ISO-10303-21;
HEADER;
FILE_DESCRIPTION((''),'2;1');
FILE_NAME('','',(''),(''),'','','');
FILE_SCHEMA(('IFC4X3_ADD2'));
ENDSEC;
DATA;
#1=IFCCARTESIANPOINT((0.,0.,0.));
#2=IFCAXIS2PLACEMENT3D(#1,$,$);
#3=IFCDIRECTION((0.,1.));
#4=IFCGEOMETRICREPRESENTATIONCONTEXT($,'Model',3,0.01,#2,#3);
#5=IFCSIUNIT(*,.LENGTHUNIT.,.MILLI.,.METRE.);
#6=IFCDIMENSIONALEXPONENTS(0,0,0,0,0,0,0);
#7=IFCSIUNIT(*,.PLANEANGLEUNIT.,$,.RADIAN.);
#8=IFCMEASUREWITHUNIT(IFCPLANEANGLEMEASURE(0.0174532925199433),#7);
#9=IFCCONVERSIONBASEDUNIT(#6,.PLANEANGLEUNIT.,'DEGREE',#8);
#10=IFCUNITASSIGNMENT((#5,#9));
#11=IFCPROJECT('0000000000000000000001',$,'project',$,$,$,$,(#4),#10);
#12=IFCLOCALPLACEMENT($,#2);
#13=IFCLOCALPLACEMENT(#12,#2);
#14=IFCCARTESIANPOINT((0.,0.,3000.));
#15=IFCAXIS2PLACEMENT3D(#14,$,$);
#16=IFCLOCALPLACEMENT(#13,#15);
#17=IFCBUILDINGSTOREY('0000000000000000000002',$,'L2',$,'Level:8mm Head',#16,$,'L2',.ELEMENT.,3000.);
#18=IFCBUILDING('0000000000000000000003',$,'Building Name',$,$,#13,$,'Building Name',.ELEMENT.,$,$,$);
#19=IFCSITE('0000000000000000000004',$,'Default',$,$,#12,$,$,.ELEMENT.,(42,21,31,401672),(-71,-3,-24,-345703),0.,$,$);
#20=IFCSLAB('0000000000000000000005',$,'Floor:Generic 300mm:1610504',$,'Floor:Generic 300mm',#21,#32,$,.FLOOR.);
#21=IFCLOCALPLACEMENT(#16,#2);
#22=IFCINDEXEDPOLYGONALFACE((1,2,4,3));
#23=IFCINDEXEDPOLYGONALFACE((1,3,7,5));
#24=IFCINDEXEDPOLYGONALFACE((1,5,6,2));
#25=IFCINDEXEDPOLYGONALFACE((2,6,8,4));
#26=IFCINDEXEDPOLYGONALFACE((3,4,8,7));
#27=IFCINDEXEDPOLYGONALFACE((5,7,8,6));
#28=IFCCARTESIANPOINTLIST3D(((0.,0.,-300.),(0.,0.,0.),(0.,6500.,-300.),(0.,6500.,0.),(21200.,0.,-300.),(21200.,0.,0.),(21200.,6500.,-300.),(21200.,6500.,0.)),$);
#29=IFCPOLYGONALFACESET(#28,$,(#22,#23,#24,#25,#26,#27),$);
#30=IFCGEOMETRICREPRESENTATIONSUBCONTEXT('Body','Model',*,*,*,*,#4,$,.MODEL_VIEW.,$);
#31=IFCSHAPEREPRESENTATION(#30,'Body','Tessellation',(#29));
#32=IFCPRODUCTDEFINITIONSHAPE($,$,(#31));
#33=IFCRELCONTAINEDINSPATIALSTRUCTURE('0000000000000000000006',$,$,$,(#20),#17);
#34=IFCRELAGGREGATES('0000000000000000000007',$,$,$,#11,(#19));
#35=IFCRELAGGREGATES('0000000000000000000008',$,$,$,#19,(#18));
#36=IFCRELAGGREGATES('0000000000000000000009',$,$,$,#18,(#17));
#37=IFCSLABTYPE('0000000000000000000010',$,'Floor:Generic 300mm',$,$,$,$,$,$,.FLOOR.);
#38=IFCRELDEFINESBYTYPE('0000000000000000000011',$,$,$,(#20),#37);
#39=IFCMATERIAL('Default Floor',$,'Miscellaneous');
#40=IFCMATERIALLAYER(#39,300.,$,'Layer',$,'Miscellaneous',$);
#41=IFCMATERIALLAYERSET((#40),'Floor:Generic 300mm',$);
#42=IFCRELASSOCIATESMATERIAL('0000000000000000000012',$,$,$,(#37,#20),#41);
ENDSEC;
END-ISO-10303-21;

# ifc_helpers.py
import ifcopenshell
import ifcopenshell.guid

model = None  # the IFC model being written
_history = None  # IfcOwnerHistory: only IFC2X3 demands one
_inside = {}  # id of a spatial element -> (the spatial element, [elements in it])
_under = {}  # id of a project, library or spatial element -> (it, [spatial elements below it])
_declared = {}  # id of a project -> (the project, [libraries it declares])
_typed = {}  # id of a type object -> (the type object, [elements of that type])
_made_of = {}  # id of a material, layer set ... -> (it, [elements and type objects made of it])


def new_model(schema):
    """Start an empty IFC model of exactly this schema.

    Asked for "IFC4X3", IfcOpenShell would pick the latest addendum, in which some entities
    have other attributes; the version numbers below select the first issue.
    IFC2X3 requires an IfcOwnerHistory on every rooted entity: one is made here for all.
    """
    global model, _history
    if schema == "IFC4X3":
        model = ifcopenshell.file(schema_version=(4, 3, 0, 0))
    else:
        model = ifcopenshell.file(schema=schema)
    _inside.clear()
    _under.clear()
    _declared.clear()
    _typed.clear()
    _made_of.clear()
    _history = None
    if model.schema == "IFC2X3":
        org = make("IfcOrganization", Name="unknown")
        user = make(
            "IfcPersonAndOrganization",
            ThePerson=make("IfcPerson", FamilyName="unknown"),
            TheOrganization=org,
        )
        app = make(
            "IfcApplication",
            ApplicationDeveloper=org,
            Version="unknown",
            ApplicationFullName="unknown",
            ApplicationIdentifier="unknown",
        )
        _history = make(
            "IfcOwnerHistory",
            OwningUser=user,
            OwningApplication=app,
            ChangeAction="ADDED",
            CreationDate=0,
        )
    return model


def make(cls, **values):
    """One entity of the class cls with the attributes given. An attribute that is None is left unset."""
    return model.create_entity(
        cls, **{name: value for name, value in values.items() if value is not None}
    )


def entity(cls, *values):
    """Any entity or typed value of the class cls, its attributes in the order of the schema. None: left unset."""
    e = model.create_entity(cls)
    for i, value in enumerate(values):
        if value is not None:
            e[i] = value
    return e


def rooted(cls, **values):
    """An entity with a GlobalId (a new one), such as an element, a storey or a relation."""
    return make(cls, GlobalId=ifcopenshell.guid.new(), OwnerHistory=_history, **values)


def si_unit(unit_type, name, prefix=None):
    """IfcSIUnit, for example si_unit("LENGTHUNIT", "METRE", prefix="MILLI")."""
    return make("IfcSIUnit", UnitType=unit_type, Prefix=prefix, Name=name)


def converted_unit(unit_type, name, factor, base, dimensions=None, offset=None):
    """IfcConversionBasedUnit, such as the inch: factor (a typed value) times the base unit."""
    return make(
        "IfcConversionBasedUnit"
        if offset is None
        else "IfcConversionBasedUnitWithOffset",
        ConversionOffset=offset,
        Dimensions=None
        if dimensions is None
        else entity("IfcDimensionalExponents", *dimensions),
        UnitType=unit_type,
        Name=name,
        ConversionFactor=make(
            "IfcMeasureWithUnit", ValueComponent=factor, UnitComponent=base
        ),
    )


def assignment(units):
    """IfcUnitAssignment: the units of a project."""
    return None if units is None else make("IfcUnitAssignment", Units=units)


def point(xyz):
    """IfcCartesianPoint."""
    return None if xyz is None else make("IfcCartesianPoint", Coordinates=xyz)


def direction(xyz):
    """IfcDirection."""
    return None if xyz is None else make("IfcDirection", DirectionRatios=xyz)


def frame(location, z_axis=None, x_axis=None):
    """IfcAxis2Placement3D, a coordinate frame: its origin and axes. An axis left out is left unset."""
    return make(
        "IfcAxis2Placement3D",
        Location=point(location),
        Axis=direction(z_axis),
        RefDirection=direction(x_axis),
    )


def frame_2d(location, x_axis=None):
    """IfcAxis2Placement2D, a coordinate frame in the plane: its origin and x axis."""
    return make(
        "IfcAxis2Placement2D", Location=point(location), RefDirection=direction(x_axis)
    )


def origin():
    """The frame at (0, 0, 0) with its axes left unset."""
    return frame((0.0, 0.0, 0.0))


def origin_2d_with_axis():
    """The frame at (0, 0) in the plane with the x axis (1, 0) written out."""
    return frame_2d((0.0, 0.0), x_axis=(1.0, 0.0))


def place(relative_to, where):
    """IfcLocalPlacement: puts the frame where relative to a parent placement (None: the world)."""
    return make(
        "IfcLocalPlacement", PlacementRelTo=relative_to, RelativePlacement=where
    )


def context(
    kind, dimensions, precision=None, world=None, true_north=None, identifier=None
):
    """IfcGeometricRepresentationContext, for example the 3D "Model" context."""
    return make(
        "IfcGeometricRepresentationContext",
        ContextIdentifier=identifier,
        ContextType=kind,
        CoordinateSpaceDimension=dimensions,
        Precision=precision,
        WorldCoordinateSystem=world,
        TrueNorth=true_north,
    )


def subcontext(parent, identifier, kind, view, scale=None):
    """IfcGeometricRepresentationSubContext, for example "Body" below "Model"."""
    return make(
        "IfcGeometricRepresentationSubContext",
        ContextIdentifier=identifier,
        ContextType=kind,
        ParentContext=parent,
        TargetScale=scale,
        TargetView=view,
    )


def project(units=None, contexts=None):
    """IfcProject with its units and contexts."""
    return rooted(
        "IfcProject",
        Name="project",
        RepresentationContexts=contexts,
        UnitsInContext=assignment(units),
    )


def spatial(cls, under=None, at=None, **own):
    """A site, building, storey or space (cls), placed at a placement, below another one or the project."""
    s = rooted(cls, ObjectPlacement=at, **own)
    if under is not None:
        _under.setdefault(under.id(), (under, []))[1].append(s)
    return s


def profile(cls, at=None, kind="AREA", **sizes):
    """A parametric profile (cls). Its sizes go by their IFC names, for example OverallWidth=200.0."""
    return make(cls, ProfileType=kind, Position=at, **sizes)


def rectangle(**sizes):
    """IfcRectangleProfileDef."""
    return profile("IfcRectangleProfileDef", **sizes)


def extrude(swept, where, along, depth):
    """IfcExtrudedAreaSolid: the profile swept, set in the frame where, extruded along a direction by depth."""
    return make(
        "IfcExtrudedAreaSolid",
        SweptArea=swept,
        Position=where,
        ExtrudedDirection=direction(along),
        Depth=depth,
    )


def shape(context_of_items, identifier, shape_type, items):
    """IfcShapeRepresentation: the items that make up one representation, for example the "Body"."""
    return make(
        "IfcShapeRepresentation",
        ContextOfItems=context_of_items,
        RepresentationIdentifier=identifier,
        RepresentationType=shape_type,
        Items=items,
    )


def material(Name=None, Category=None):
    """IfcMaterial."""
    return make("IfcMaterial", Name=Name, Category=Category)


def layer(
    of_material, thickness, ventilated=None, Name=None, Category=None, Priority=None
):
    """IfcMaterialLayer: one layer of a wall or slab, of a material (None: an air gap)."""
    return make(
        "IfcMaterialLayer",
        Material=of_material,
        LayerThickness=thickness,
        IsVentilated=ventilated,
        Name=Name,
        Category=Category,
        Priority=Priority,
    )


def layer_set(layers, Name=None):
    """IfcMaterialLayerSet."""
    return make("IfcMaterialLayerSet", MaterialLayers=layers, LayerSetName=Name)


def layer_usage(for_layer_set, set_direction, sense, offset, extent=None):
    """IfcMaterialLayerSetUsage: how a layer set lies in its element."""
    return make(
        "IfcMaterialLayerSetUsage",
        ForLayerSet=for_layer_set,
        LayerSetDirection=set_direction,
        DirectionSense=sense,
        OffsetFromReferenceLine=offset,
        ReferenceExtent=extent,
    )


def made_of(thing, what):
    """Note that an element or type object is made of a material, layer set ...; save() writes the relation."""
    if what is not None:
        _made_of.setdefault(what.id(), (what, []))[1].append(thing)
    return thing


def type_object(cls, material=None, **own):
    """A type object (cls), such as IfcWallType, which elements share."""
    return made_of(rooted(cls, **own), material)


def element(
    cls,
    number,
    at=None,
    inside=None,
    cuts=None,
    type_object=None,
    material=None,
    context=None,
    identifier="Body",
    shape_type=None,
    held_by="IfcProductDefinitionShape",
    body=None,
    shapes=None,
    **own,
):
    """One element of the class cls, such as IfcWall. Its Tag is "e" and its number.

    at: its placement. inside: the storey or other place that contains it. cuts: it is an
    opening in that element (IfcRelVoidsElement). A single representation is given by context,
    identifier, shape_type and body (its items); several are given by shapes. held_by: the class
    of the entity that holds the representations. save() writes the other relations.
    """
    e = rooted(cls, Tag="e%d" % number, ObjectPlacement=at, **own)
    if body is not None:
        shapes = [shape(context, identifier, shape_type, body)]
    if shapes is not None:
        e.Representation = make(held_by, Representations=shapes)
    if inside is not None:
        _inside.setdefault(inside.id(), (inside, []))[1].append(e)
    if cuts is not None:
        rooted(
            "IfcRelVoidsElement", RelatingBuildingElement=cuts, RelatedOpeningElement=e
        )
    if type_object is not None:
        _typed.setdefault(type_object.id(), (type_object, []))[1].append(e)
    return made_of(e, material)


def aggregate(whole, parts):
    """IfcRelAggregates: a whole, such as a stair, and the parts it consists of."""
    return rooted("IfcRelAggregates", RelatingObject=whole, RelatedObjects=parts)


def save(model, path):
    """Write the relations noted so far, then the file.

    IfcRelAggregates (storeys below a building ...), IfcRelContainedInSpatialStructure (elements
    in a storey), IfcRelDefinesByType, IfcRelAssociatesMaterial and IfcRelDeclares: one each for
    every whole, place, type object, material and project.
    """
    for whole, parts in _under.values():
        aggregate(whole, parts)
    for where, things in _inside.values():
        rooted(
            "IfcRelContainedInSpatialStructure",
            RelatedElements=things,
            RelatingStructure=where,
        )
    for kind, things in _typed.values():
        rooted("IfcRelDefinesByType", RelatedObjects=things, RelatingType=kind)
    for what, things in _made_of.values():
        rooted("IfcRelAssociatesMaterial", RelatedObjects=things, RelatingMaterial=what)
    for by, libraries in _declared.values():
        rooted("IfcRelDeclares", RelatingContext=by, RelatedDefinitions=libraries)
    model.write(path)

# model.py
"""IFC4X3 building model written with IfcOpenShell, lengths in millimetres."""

from ifc_helpers import new_model, entity, si_unit, converted_unit, direction, frame, origin, origin_2d_with_axis, place, context, subcontext, project, spatial, rectangle, extrude, material, layer, layer_set, layer_usage, type_object, element, save


model = new_model("IFC4X3")

# Units and contexts
model_context = context("Model", 3, precision=0.01, world=origin(), true_north=direction((0.0, 1.0)))
body_context = subcontext(model_context, "Body", "Model", "MODEL_VIEW")
ifc_project = project(units=[si_unit("LENGTHUNIT", "METRE", prefix="MILLI"), converted_unit("PLANEANGLEUNIT", "DEGREE", entity("IfcPlaneAngleMeasure", 0.0174532925199433), si_unit("PLANEANGLEUNIT", "RADIAN"), dimensions=[0, 0, 0, 0, 0, 0, 0])], contexts=[model_context])

# Site, building, storey
site_placement = place(None, origin())
site = spatial("IfcSite", under=ifc_project, at=site_placement, Name="Default", CompositionType="ELEMENT", RefLatitude=(42, 21, 31, 401672), RefLongitude=(-71, -3, -24, -345703), RefElevation=0.0)
building_placement = place(site_placement, origin())
building = spatial("IfcBuilding", under=site, at=building_placement, Name="Building Name", LongName="Building Name", CompositionType="ELEMENT")
storey_placement = place(building_placement, frame((0.0, 0.0, 3000.0)))
storey = spatial("IfcBuildingStorey", under=building, at=storey_placement, Name="L2", ObjectType="Level:8mm Head", LongName="L2", CompositionType="ELEMENT", Elevation=3000.0)

# Slab
ifc_material = material(Name="Default Floor", Category="Miscellaneous")
ifc_layer = layer(ifc_material, 300.0, Name="Layer", Category="Miscellaneous")
ifc_layer_set = layer_set([ifc_layer], Name="Floor:Generic 300mm")
ifc_layer_usage = layer_usage(ifc_layer_set, "AXIS3", "POSITIVE", 0.0)
slab_type = type_object("IfcSlabType", Name="Floor:Generic 300mm", PredefinedType="FLOOR", material=ifc_layer_set)
slab_placement = place(storey_placement, origin())
element("IfcSlab", 1, at=slab_placement, inside=storey, type_object=slab_type, material=ifc_layer_usage, Name="Floor:Generic 300mm:1610504", ObjectType="Floor:Generic 300mm", PredefinedType="FLOOR", context=body_context, shape_type="SweptSolid", body=[
    extrude(rectangle(XDim=6500.0, YDim=21200.0, at=origin_2d_with_axis()), frame((10600.0, 3250.0, 0.0), z_axis=(0.0, 0.0, -1.0), x_axis=(0.0, 1.0, 0.0)), (0.0, 0.0, 1.0), 300.0),
])

save(model, "model.ifc")
